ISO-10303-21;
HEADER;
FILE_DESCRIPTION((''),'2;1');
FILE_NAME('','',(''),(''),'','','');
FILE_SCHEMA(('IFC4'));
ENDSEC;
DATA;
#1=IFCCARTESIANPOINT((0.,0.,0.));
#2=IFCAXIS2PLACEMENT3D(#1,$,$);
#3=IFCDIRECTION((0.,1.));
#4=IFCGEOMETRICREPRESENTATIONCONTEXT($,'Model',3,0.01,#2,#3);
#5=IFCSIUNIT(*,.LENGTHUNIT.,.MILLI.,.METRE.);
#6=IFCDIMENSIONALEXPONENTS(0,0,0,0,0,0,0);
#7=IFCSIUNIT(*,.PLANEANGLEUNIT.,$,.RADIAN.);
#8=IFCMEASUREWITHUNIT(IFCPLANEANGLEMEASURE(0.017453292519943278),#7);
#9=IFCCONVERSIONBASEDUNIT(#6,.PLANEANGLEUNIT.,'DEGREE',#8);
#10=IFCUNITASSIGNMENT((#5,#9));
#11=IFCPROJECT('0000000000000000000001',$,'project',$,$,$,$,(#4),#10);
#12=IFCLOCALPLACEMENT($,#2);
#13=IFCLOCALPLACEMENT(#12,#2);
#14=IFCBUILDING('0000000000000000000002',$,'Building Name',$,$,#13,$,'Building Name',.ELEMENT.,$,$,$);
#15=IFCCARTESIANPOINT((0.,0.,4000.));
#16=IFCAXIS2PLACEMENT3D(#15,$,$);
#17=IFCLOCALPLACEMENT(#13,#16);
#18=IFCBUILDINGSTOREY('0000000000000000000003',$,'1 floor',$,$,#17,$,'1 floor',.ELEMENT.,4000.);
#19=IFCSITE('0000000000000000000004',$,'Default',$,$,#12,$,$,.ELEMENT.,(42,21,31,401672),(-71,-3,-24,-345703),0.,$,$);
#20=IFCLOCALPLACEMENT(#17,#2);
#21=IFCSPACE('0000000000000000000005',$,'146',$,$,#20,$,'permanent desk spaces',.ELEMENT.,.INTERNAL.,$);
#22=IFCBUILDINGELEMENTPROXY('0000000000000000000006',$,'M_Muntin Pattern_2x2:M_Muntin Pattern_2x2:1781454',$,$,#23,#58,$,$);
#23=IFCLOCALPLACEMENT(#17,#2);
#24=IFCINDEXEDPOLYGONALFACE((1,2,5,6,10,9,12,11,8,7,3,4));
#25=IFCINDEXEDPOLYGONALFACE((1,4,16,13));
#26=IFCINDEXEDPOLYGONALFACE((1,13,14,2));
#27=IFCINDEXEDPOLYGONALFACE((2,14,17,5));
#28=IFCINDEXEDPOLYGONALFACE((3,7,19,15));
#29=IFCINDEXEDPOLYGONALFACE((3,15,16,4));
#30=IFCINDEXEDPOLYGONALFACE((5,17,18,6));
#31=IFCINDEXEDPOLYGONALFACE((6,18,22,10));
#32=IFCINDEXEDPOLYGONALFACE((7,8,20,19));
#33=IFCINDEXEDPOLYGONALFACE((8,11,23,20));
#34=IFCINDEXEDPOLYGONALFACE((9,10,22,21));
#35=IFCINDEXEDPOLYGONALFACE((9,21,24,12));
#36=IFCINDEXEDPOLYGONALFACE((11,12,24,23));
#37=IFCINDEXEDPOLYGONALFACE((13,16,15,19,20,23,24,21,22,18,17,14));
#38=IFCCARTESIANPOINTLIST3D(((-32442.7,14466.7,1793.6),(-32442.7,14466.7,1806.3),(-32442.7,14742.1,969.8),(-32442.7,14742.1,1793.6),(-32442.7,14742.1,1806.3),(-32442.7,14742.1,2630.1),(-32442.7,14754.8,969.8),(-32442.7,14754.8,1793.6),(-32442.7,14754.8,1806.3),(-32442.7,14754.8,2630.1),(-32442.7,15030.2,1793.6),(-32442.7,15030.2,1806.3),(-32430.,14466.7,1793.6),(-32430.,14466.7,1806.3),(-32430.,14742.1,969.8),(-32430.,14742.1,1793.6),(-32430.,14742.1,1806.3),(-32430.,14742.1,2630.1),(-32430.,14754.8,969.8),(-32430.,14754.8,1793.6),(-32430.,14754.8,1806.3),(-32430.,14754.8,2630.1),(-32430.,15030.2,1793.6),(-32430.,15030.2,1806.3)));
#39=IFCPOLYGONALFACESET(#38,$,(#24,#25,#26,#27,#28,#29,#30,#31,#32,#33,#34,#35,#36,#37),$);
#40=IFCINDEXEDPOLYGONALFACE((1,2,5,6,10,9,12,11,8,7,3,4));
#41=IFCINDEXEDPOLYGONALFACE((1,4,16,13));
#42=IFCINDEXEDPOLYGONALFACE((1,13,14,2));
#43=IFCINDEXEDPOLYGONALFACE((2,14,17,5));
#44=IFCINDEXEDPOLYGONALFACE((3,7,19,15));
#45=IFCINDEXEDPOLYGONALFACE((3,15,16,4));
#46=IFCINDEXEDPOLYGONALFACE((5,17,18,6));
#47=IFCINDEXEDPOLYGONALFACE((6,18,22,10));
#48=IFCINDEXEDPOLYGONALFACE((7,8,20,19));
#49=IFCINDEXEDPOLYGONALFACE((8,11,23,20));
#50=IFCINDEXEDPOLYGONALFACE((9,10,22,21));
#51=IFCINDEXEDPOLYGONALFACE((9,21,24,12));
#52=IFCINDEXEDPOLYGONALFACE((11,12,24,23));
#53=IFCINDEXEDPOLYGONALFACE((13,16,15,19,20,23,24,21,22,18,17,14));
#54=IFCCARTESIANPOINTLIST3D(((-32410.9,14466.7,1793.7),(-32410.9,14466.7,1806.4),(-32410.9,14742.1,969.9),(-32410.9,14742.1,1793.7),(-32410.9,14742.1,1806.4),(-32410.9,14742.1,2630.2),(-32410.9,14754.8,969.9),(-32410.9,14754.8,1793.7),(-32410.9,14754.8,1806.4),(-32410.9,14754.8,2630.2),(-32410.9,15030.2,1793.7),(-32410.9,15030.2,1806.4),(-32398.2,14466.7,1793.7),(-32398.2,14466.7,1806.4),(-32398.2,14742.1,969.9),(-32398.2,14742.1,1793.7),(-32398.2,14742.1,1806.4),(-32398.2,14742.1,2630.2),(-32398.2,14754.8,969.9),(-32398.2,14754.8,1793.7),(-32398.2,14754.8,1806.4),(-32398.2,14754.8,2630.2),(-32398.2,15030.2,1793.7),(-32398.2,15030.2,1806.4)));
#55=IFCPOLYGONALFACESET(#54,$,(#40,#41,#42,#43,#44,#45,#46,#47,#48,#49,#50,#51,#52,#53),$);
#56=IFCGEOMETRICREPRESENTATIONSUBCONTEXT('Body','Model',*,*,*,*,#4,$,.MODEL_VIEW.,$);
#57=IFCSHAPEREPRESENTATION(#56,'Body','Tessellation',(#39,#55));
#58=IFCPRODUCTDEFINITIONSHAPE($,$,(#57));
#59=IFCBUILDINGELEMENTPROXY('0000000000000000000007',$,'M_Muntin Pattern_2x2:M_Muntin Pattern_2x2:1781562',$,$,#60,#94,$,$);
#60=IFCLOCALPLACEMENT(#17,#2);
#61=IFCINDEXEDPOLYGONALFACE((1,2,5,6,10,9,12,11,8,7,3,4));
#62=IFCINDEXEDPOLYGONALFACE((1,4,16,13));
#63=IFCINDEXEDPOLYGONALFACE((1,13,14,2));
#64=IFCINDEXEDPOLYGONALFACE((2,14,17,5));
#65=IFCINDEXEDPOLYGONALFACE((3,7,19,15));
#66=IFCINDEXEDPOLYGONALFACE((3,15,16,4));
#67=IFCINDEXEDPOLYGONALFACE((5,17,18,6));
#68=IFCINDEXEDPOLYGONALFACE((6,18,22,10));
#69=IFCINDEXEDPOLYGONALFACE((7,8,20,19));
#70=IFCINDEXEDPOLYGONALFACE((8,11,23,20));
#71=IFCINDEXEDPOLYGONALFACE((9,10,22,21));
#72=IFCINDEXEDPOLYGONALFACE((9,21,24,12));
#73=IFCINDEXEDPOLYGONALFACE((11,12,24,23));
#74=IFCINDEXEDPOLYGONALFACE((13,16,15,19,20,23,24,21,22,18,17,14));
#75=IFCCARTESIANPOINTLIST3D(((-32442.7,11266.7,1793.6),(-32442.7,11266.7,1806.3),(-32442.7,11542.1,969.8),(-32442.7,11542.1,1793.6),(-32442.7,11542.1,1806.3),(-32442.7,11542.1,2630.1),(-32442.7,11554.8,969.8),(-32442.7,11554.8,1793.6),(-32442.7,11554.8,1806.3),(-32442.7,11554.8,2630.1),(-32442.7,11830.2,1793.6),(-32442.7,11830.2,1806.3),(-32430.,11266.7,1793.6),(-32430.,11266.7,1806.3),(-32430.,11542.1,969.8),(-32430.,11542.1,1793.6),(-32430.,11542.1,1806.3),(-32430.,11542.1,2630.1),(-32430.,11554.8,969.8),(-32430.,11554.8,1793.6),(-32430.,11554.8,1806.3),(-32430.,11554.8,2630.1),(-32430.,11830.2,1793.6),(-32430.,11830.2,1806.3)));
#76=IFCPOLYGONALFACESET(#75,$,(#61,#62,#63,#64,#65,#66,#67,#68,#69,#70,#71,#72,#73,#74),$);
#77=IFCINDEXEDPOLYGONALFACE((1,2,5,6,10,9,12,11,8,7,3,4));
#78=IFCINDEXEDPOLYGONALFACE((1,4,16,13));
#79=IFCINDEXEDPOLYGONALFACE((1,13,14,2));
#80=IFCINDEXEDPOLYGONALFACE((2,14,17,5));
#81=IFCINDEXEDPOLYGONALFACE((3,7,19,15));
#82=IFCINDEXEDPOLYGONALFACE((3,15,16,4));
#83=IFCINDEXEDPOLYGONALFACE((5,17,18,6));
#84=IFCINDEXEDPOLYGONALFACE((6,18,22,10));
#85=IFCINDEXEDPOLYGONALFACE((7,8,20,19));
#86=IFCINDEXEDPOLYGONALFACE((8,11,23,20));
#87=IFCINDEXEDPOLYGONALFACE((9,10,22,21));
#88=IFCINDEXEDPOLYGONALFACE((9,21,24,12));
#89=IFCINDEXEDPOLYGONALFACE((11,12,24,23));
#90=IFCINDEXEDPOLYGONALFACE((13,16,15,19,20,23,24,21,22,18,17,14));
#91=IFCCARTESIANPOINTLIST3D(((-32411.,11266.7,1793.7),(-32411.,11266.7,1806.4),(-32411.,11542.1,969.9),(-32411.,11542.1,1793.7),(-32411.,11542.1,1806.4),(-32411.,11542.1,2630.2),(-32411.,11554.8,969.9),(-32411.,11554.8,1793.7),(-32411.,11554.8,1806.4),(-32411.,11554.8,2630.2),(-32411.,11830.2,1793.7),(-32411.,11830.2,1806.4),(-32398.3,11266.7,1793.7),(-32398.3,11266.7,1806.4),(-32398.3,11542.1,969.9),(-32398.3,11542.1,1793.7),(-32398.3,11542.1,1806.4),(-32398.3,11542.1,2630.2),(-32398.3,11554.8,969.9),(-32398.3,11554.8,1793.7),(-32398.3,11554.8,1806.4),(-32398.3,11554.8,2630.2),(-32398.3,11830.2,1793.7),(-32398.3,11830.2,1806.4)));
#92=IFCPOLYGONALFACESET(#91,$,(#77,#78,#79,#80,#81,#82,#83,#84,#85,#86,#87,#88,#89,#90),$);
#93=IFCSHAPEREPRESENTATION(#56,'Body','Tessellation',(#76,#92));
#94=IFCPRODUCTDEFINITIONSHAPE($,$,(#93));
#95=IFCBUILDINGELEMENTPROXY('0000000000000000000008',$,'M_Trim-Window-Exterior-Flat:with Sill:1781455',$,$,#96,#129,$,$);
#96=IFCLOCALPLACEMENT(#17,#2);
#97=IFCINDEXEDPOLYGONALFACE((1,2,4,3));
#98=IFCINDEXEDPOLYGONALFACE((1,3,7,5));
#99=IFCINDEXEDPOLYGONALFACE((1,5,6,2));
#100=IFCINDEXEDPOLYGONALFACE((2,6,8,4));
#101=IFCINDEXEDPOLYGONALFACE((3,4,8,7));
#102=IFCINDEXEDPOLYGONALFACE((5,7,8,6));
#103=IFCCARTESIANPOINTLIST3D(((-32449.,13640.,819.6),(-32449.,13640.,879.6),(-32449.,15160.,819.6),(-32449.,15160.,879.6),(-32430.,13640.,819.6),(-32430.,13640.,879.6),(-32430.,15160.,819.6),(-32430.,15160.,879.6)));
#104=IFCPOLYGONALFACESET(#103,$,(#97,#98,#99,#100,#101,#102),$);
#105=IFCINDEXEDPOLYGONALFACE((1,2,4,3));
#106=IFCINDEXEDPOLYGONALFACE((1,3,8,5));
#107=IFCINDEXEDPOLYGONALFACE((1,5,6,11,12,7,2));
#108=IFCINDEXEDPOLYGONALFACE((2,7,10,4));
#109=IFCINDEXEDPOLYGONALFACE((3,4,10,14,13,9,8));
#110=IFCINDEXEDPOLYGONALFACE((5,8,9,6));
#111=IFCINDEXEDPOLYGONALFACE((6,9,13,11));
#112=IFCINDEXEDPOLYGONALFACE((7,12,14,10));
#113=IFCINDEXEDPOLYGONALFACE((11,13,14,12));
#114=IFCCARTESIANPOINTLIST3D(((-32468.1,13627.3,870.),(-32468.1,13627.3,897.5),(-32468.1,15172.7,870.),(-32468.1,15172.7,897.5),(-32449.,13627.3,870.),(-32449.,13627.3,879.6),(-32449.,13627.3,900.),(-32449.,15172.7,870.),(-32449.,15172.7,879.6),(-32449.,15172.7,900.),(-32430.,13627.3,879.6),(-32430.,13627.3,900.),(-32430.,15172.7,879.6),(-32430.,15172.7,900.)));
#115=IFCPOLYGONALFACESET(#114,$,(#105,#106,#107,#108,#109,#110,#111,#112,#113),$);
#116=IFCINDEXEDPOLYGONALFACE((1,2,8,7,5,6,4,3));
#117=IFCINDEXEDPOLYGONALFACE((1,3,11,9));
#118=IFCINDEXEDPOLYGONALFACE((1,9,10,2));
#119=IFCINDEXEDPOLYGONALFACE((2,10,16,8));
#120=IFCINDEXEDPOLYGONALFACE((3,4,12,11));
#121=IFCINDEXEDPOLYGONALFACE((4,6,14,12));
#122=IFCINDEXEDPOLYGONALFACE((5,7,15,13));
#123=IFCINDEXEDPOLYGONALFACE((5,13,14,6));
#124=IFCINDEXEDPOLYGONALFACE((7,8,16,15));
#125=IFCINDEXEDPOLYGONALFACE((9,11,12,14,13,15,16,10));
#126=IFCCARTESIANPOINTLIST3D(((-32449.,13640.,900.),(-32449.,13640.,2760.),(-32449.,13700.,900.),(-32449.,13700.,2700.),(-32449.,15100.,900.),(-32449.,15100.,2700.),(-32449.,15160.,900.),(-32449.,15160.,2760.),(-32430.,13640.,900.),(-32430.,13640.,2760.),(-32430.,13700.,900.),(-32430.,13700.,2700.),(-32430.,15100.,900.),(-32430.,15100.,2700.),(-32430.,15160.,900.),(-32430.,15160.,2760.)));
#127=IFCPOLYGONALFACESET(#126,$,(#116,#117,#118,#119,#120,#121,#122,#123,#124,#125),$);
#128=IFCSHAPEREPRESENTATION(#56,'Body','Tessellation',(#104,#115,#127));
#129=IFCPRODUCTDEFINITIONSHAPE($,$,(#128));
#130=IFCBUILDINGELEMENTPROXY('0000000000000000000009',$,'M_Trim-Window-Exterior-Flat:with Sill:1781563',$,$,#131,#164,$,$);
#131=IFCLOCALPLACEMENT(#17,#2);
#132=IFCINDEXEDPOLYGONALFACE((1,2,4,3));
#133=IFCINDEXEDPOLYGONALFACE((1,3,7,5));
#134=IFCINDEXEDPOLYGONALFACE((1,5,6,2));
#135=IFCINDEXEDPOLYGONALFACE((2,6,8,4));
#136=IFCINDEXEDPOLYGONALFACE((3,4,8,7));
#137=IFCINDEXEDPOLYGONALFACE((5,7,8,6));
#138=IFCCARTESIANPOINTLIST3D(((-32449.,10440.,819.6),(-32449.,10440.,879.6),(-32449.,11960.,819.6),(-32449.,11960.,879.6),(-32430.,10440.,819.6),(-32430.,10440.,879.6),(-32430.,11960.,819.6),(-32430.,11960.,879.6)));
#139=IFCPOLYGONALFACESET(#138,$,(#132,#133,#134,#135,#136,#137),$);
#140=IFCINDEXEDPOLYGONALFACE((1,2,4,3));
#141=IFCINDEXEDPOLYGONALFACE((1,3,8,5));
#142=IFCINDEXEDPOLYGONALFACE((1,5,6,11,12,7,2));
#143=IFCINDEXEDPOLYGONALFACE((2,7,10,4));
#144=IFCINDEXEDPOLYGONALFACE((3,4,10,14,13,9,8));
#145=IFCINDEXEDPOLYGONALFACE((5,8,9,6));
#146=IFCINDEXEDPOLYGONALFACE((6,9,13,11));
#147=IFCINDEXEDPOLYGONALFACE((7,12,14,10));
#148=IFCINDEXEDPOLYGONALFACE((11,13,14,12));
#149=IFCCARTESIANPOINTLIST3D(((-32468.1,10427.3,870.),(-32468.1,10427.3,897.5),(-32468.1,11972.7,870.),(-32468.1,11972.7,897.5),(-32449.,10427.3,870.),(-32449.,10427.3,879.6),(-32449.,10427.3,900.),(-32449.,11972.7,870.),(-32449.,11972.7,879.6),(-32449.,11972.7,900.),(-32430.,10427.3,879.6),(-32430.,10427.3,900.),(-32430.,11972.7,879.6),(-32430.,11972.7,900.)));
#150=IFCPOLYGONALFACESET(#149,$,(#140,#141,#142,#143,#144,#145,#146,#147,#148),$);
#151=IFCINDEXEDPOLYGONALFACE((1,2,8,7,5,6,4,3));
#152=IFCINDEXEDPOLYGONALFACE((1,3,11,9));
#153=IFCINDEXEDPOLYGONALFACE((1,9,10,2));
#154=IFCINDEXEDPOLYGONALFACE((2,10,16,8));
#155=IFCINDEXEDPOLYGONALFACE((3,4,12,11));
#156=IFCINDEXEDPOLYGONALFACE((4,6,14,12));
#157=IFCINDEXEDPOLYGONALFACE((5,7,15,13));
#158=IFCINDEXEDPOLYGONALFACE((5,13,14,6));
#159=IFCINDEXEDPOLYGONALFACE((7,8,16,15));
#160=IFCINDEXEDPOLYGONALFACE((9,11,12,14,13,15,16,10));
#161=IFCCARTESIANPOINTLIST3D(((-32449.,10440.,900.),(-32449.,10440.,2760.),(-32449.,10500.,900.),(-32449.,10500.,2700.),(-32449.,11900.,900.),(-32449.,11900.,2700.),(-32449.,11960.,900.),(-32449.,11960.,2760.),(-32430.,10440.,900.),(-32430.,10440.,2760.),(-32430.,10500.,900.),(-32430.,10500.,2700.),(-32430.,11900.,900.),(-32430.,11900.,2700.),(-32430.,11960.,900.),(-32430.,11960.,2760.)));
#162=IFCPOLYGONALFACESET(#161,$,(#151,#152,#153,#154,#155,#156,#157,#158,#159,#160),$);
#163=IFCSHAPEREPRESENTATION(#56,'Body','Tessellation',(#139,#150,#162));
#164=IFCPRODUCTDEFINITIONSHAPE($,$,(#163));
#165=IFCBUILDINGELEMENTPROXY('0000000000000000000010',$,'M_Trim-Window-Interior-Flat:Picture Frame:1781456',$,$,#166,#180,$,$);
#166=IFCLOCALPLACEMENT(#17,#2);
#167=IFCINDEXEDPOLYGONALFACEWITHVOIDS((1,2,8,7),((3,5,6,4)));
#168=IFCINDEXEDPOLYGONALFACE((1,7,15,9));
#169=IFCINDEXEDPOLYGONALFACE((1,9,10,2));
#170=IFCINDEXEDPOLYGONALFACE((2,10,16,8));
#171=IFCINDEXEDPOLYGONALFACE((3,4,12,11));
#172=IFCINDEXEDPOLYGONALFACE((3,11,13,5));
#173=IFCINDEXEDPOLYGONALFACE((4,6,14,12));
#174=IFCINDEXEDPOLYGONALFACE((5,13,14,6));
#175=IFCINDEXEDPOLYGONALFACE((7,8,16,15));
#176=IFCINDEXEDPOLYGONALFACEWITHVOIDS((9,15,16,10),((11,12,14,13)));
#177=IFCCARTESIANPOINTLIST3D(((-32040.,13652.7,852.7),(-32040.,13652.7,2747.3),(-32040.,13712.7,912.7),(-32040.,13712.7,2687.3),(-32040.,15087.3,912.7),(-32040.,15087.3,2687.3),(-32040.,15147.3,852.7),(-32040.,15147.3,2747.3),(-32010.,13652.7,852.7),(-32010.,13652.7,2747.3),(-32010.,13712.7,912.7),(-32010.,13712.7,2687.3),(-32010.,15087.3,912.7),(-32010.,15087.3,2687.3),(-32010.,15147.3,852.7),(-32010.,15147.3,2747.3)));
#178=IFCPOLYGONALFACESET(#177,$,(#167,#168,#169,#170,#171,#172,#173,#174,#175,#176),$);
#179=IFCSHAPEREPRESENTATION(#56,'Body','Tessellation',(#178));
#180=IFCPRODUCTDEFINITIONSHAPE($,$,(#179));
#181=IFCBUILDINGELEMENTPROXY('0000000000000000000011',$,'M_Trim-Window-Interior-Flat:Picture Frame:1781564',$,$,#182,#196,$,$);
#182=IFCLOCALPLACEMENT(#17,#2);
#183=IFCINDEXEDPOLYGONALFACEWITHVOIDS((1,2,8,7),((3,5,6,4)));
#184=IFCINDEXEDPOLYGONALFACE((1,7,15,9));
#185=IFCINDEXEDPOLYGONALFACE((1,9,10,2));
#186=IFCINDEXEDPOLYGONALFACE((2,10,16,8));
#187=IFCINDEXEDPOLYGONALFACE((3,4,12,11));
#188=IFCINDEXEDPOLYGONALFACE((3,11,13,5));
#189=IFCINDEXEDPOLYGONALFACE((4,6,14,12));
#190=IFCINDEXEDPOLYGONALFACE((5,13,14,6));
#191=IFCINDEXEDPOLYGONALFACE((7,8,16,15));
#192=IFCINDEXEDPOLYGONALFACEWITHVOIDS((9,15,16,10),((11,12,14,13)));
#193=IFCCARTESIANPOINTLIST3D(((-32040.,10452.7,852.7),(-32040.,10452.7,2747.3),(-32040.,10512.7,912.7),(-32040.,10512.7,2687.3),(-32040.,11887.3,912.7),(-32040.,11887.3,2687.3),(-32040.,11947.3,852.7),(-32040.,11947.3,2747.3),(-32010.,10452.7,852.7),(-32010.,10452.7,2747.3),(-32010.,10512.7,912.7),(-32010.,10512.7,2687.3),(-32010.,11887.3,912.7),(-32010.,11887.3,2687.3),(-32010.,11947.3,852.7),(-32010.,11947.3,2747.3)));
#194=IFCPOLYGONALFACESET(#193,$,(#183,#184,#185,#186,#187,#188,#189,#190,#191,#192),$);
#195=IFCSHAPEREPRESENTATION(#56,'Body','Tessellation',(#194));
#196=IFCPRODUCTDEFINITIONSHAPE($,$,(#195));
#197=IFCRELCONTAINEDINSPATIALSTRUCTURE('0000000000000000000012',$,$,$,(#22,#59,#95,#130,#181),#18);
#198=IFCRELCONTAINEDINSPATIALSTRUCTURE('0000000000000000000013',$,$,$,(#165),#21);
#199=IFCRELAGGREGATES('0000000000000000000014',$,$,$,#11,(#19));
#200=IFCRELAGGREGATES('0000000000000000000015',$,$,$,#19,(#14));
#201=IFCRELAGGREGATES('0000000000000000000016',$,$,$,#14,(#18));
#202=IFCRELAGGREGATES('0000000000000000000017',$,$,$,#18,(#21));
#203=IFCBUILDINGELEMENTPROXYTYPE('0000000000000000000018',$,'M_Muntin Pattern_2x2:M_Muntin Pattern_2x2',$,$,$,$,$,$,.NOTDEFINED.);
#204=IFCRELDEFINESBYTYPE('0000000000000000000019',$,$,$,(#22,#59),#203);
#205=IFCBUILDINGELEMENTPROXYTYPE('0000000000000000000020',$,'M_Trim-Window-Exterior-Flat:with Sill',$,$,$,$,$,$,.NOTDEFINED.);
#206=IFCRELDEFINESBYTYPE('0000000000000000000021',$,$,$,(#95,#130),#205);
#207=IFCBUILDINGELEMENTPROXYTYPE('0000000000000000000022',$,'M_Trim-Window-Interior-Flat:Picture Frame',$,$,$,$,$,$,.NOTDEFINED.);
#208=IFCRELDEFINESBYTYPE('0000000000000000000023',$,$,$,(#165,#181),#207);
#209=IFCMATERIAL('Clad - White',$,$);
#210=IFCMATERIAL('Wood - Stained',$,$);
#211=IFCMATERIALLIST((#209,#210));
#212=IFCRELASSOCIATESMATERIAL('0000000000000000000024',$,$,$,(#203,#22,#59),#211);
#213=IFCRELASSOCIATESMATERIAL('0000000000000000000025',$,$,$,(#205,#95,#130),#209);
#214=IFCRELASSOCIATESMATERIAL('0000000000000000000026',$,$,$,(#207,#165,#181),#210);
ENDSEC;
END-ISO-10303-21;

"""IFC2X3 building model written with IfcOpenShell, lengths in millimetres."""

from ifc_helpers import new_model, entity, si_unit, converted_unit, direction, frame, frame_2d, origin, place, context, subcontext, project, spatial, polyline, rectangle, outline, extrude, source, transform, mapped, material, material_list, type_object, type_shapes, element, save


model = new_model("IFC2X3")

# Units and contexts
model_context = context("Model", 3, precision=0.01, world=origin(), true_north=direction((0.0, 1.0)))
body_context = subcontext(model_context, "Body", "Model", "MODEL_VIEW")
ifc_project = project(units=[si_unit("LENGTHUNIT", "METRE", prefix="MILLI"), converted_unit("PLANEANGLEUNIT", "DEGREE", entity("IfcPlaneAngleMeasure", 0.017453292519943278), si_unit("PLANEANGLEUNIT", "RADIAN"), dimensions=[0, 0, 0, 0, 0, 0, 0])], contexts=[model_context])

# Site, building, storey
site_placement = place(None, origin())
site = spatial("IfcSite", under=ifc_project, at=site_placement, Name="Default", CompositionType="ELEMENT", RefLatitude=(42, 21, 31, 401672), RefLongitude=(-71, -3, -24, -345703), RefElevation=0.0)
building_placement = place(site_placement, origin())
building = spatial("IfcBuilding", under=site, at=building_placement, Name="Building Name", LongName="Building Name", CompositionType="ELEMENT")
storey_placement = place(building_placement, frame((0.0, 0.0, 4000.0)))
storey = spatial("IfcBuildingStorey", under=building, at=storey_placement, Name="1 floor", LongName="1 floor", CompositionType="ELEMENT", Elevation=4000.0)

# Shared definitions
ifc_material_1 = material(Name="Clad - White")
ifc_material_2 = material(Name="Wood - Stained")
ifc_material_list = material_list([ifc_material_1, ifc_material_2])

# Shared definitions
space_placement = place(storey_placement, origin())
space = spatial("IfcSpace", under=storey, at=space_placement, Name="146", LongName="permanent desk spaces", CompositionType="ELEMENT", InteriorOrExteriorSpace="INTERNAL")

# Building element proxies
building_element_proxy_type_1 = type_object("IfcBuildingElementProxyType", Name="M_Muntin Pattern_2x2:M_Muntin Pattern_2x2", PredefinedType="NOTDEFINED", material=ifc_material_list)
shared_shape_1 = source(origin(), body_context, "Body", "SweptSolid", [
    extrude(outline(polyline([(6.4, -6.4), (830.1, -6.4), (830.1, 6.3), (6.4, 6.3), (6.4, 281.7), (-6.3, 281.7), (-6.3, 6.3), (-830.2, 6.3), (-830.2, -6.4), (-6.3, -6.4), (-6.3, -281.7), (6.4, -281.7), (6.4, -6.4)])), frame((0.0, -22.2, 830.1), z_axis=(0.0, 1.0, 0.0), x_axis=(0.0, 0.0, 1.0)), (0.0, 0.0, 1.0), 12.7),
    extrude(outline(polyline([(6.4, -6.4), (830.2, -6.4), (830.2, 6.3), (6.4, 6.3), (6.4, 281.7), (-6.3, 281.7), (-6.3, 6.3), (-830.2, 6.3), (-830.2, -6.4), (-6.3, -6.4), (-6.3, -281.7), (6.4, -281.7), (6.4, -6.4)])), frame((0.0, 9.5, 830.2), z_axis=(0.0, 1.0, 0.0), x_axis=(0.0, 0.0, 1.0)), (0.0, 0.0, 1.0), 12.7),
])
type_shapes(building_element_proxy_type_1, [shared_shape_1])
for number, where, z_axis, x_axis, name in (
    (1, (-32420.5, 14748.4, 969.9), (0.0, 0.0, 1.0), (0.0, -1.0, 0.0), "M_Muntin Pattern_2x2:M_Muntin Pattern_2x2:1781454"),
    (2, (-32420.5, 11548.4, 969.9), (0.0, 0.0, 1.0), (0.0, -1.0, 0.0), "M_Muntin Pattern_2x2:M_Muntin Pattern_2x2:1781562"),
):
    element("IfcBuildingElementProxy", number, at=place(storey_placement, frame(where, z_axis=z_axis, x_axis=x_axis)), inside=storey, type_object=building_element_proxy_type_1, material=ifc_material_list, Name=name, context=body_context, shape_type="MappedRepresentation", body=[
        mapped(shared_shape_1, transform((0.0, 0.0, 0.0), scale=1.0)),
    ])
building_element_proxy_type_2 = type_object("IfcBuildingElementProxyType", Name="M_Trim-Window-Exterior-Flat:with Sill", PredefinedType="NOTDEFINED", material=ifc_material_1)
shared_shape_2 = source(origin(), body_context, "Body", "SweptSolid", [
    extrude(rectangle(XDim=1520.0, YDim=60.0, at=frame_2d((0.0, 0.0), x_axis=(1.0, 0.0))), frame((0.0, -1850.4, 0.0), z_axis=(0.0, 0.0, 1.0), x_axis=(-1.0, 0.0, 0.0)), (0.0, 0.0, 1.0), 19.0),
    extrude(outline(polyline([(-19.0, -15.2), (0.0, -15.2), (0.0, -5.7), (19.0, -5.7), (19.0, 14.8), (0.0, 14.8), (-19.0, 12.3), (-19.0, -15.2)])), frame((-772.7, -1814.8, 19.0), z_axis=(1.0, 0.0, 0.0), x_axis=(0.0, 0.0, -1.0)), (0.0, 0.0, 1.0), 1545.4),
    extrude(outline(polyline([(-945.0, -760.0), (915.0, -760.0), (915.0, -700.0), (-885.0, -700.0), (-885.0, 700.0), (915.0, 700.0), (915.0, 760.0), (-945.0, 760.0), (-945.0, -760.0)])), frame((0.0, -885.0, 0.0), z_axis=(0.0, 0.0, 1.0), x_axis=(0.0, -1.0, 0.0)), (0.0, 0.0, 1.0), 19.0),
])
type_shapes(building_element_proxy_type_2, [shared_shape_2])
for number, where, z_axis, x_axis, name in (
    (3, (-32430.0, 14400.0, 2700.0), (-1.0, 0.0, 0.0), (0.0, -1.0, 0.0), "M_Trim-Window-Exterior-Flat:with Sill:1781455"),
    (4, (-32430.0, 11200.0, 2700.0), (-1.0, 0.0, 0.0), (0.0, -1.0, 0.0), "M_Trim-Window-Exterior-Flat:with Sill:1781563"),
):
    element("IfcBuildingElementProxy", number, at=place(storey_placement, frame(where, z_axis=z_axis, x_axis=x_axis)), inside=storey, type_object=building_element_proxy_type_2, material=ifc_material_1, Name=name, context=body_context, shape_type="MappedRepresentation", body=[
        mapped(shared_shape_2, transform((0.0, 0.0, 0.0), scale=1.0)),
    ])
building_element_proxy_type_3 = type_object("IfcBuildingElementProxyType", Name="M_Trim-Window-Interior-Flat:Picture Frame", PredefinedType="NOTDEFINED", material=ifc_material_2)
shared_shape_3 = source(origin(), body_context, "Body", "SweptSolid", [
    extrude(outline(polyline([(-747.3, -947.3), (747.3, -947.3), (747.3, 947.3), (-747.3, 947.3), (-747.3, -947.3)]), holes=[polyline([(-687.3, -887.3), (-687.3, 887.3), (687.3, 887.3), (687.3, -887.3), (-687.3, -887.3)])]), frame((0.0, -900.0, 0.0), z_axis=(0.0, 0.0, 1.0), x_axis=(-1.0, 0.0, 0.0)), (0.0, 0.0, 1.0), 30.0),
])
type_shapes(building_element_proxy_type_3, [shared_shape_3])
proxy_1_placement = place(space_placement, frame((-32040.0, 14400.0, 2700.0), z_axis=(1.0, 0.0, 0.0), x_axis=(0.0, 1.0, 0.0)))
element("IfcBuildingElementProxy", 5, at=proxy_1_placement, inside=space, type_object=building_element_proxy_type_3, material=ifc_material_2, Name="M_Trim-Window-Interior-Flat:Picture Frame:1781456", context=body_context, shape_type="MappedRepresentation", body=[
    mapped(shared_shape_3, transform((0.0, 0.0, 0.0), scale=1.0)),
])
proxy_2_placement = place(storey_placement, frame((-32040.0, 11200.0, 2700.0), z_axis=(1.0, 0.0, 0.0), x_axis=(0.0, 1.0, 0.0)))
element("IfcBuildingElementProxy", 6, at=proxy_2_placement, inside=storey, type_object=building_element_proxy_type_3, material=ifc_material_2, Name="M_Trim-Window-Interior-Flat:Picture Frame:1781564", context=body_context, shape_type="MappedRepresentation", body=[
    mapped(shared_shape_3, transform((0.0, 0.0, 0.0), scale=1.0)),
])

save(model, "model.ifc")
